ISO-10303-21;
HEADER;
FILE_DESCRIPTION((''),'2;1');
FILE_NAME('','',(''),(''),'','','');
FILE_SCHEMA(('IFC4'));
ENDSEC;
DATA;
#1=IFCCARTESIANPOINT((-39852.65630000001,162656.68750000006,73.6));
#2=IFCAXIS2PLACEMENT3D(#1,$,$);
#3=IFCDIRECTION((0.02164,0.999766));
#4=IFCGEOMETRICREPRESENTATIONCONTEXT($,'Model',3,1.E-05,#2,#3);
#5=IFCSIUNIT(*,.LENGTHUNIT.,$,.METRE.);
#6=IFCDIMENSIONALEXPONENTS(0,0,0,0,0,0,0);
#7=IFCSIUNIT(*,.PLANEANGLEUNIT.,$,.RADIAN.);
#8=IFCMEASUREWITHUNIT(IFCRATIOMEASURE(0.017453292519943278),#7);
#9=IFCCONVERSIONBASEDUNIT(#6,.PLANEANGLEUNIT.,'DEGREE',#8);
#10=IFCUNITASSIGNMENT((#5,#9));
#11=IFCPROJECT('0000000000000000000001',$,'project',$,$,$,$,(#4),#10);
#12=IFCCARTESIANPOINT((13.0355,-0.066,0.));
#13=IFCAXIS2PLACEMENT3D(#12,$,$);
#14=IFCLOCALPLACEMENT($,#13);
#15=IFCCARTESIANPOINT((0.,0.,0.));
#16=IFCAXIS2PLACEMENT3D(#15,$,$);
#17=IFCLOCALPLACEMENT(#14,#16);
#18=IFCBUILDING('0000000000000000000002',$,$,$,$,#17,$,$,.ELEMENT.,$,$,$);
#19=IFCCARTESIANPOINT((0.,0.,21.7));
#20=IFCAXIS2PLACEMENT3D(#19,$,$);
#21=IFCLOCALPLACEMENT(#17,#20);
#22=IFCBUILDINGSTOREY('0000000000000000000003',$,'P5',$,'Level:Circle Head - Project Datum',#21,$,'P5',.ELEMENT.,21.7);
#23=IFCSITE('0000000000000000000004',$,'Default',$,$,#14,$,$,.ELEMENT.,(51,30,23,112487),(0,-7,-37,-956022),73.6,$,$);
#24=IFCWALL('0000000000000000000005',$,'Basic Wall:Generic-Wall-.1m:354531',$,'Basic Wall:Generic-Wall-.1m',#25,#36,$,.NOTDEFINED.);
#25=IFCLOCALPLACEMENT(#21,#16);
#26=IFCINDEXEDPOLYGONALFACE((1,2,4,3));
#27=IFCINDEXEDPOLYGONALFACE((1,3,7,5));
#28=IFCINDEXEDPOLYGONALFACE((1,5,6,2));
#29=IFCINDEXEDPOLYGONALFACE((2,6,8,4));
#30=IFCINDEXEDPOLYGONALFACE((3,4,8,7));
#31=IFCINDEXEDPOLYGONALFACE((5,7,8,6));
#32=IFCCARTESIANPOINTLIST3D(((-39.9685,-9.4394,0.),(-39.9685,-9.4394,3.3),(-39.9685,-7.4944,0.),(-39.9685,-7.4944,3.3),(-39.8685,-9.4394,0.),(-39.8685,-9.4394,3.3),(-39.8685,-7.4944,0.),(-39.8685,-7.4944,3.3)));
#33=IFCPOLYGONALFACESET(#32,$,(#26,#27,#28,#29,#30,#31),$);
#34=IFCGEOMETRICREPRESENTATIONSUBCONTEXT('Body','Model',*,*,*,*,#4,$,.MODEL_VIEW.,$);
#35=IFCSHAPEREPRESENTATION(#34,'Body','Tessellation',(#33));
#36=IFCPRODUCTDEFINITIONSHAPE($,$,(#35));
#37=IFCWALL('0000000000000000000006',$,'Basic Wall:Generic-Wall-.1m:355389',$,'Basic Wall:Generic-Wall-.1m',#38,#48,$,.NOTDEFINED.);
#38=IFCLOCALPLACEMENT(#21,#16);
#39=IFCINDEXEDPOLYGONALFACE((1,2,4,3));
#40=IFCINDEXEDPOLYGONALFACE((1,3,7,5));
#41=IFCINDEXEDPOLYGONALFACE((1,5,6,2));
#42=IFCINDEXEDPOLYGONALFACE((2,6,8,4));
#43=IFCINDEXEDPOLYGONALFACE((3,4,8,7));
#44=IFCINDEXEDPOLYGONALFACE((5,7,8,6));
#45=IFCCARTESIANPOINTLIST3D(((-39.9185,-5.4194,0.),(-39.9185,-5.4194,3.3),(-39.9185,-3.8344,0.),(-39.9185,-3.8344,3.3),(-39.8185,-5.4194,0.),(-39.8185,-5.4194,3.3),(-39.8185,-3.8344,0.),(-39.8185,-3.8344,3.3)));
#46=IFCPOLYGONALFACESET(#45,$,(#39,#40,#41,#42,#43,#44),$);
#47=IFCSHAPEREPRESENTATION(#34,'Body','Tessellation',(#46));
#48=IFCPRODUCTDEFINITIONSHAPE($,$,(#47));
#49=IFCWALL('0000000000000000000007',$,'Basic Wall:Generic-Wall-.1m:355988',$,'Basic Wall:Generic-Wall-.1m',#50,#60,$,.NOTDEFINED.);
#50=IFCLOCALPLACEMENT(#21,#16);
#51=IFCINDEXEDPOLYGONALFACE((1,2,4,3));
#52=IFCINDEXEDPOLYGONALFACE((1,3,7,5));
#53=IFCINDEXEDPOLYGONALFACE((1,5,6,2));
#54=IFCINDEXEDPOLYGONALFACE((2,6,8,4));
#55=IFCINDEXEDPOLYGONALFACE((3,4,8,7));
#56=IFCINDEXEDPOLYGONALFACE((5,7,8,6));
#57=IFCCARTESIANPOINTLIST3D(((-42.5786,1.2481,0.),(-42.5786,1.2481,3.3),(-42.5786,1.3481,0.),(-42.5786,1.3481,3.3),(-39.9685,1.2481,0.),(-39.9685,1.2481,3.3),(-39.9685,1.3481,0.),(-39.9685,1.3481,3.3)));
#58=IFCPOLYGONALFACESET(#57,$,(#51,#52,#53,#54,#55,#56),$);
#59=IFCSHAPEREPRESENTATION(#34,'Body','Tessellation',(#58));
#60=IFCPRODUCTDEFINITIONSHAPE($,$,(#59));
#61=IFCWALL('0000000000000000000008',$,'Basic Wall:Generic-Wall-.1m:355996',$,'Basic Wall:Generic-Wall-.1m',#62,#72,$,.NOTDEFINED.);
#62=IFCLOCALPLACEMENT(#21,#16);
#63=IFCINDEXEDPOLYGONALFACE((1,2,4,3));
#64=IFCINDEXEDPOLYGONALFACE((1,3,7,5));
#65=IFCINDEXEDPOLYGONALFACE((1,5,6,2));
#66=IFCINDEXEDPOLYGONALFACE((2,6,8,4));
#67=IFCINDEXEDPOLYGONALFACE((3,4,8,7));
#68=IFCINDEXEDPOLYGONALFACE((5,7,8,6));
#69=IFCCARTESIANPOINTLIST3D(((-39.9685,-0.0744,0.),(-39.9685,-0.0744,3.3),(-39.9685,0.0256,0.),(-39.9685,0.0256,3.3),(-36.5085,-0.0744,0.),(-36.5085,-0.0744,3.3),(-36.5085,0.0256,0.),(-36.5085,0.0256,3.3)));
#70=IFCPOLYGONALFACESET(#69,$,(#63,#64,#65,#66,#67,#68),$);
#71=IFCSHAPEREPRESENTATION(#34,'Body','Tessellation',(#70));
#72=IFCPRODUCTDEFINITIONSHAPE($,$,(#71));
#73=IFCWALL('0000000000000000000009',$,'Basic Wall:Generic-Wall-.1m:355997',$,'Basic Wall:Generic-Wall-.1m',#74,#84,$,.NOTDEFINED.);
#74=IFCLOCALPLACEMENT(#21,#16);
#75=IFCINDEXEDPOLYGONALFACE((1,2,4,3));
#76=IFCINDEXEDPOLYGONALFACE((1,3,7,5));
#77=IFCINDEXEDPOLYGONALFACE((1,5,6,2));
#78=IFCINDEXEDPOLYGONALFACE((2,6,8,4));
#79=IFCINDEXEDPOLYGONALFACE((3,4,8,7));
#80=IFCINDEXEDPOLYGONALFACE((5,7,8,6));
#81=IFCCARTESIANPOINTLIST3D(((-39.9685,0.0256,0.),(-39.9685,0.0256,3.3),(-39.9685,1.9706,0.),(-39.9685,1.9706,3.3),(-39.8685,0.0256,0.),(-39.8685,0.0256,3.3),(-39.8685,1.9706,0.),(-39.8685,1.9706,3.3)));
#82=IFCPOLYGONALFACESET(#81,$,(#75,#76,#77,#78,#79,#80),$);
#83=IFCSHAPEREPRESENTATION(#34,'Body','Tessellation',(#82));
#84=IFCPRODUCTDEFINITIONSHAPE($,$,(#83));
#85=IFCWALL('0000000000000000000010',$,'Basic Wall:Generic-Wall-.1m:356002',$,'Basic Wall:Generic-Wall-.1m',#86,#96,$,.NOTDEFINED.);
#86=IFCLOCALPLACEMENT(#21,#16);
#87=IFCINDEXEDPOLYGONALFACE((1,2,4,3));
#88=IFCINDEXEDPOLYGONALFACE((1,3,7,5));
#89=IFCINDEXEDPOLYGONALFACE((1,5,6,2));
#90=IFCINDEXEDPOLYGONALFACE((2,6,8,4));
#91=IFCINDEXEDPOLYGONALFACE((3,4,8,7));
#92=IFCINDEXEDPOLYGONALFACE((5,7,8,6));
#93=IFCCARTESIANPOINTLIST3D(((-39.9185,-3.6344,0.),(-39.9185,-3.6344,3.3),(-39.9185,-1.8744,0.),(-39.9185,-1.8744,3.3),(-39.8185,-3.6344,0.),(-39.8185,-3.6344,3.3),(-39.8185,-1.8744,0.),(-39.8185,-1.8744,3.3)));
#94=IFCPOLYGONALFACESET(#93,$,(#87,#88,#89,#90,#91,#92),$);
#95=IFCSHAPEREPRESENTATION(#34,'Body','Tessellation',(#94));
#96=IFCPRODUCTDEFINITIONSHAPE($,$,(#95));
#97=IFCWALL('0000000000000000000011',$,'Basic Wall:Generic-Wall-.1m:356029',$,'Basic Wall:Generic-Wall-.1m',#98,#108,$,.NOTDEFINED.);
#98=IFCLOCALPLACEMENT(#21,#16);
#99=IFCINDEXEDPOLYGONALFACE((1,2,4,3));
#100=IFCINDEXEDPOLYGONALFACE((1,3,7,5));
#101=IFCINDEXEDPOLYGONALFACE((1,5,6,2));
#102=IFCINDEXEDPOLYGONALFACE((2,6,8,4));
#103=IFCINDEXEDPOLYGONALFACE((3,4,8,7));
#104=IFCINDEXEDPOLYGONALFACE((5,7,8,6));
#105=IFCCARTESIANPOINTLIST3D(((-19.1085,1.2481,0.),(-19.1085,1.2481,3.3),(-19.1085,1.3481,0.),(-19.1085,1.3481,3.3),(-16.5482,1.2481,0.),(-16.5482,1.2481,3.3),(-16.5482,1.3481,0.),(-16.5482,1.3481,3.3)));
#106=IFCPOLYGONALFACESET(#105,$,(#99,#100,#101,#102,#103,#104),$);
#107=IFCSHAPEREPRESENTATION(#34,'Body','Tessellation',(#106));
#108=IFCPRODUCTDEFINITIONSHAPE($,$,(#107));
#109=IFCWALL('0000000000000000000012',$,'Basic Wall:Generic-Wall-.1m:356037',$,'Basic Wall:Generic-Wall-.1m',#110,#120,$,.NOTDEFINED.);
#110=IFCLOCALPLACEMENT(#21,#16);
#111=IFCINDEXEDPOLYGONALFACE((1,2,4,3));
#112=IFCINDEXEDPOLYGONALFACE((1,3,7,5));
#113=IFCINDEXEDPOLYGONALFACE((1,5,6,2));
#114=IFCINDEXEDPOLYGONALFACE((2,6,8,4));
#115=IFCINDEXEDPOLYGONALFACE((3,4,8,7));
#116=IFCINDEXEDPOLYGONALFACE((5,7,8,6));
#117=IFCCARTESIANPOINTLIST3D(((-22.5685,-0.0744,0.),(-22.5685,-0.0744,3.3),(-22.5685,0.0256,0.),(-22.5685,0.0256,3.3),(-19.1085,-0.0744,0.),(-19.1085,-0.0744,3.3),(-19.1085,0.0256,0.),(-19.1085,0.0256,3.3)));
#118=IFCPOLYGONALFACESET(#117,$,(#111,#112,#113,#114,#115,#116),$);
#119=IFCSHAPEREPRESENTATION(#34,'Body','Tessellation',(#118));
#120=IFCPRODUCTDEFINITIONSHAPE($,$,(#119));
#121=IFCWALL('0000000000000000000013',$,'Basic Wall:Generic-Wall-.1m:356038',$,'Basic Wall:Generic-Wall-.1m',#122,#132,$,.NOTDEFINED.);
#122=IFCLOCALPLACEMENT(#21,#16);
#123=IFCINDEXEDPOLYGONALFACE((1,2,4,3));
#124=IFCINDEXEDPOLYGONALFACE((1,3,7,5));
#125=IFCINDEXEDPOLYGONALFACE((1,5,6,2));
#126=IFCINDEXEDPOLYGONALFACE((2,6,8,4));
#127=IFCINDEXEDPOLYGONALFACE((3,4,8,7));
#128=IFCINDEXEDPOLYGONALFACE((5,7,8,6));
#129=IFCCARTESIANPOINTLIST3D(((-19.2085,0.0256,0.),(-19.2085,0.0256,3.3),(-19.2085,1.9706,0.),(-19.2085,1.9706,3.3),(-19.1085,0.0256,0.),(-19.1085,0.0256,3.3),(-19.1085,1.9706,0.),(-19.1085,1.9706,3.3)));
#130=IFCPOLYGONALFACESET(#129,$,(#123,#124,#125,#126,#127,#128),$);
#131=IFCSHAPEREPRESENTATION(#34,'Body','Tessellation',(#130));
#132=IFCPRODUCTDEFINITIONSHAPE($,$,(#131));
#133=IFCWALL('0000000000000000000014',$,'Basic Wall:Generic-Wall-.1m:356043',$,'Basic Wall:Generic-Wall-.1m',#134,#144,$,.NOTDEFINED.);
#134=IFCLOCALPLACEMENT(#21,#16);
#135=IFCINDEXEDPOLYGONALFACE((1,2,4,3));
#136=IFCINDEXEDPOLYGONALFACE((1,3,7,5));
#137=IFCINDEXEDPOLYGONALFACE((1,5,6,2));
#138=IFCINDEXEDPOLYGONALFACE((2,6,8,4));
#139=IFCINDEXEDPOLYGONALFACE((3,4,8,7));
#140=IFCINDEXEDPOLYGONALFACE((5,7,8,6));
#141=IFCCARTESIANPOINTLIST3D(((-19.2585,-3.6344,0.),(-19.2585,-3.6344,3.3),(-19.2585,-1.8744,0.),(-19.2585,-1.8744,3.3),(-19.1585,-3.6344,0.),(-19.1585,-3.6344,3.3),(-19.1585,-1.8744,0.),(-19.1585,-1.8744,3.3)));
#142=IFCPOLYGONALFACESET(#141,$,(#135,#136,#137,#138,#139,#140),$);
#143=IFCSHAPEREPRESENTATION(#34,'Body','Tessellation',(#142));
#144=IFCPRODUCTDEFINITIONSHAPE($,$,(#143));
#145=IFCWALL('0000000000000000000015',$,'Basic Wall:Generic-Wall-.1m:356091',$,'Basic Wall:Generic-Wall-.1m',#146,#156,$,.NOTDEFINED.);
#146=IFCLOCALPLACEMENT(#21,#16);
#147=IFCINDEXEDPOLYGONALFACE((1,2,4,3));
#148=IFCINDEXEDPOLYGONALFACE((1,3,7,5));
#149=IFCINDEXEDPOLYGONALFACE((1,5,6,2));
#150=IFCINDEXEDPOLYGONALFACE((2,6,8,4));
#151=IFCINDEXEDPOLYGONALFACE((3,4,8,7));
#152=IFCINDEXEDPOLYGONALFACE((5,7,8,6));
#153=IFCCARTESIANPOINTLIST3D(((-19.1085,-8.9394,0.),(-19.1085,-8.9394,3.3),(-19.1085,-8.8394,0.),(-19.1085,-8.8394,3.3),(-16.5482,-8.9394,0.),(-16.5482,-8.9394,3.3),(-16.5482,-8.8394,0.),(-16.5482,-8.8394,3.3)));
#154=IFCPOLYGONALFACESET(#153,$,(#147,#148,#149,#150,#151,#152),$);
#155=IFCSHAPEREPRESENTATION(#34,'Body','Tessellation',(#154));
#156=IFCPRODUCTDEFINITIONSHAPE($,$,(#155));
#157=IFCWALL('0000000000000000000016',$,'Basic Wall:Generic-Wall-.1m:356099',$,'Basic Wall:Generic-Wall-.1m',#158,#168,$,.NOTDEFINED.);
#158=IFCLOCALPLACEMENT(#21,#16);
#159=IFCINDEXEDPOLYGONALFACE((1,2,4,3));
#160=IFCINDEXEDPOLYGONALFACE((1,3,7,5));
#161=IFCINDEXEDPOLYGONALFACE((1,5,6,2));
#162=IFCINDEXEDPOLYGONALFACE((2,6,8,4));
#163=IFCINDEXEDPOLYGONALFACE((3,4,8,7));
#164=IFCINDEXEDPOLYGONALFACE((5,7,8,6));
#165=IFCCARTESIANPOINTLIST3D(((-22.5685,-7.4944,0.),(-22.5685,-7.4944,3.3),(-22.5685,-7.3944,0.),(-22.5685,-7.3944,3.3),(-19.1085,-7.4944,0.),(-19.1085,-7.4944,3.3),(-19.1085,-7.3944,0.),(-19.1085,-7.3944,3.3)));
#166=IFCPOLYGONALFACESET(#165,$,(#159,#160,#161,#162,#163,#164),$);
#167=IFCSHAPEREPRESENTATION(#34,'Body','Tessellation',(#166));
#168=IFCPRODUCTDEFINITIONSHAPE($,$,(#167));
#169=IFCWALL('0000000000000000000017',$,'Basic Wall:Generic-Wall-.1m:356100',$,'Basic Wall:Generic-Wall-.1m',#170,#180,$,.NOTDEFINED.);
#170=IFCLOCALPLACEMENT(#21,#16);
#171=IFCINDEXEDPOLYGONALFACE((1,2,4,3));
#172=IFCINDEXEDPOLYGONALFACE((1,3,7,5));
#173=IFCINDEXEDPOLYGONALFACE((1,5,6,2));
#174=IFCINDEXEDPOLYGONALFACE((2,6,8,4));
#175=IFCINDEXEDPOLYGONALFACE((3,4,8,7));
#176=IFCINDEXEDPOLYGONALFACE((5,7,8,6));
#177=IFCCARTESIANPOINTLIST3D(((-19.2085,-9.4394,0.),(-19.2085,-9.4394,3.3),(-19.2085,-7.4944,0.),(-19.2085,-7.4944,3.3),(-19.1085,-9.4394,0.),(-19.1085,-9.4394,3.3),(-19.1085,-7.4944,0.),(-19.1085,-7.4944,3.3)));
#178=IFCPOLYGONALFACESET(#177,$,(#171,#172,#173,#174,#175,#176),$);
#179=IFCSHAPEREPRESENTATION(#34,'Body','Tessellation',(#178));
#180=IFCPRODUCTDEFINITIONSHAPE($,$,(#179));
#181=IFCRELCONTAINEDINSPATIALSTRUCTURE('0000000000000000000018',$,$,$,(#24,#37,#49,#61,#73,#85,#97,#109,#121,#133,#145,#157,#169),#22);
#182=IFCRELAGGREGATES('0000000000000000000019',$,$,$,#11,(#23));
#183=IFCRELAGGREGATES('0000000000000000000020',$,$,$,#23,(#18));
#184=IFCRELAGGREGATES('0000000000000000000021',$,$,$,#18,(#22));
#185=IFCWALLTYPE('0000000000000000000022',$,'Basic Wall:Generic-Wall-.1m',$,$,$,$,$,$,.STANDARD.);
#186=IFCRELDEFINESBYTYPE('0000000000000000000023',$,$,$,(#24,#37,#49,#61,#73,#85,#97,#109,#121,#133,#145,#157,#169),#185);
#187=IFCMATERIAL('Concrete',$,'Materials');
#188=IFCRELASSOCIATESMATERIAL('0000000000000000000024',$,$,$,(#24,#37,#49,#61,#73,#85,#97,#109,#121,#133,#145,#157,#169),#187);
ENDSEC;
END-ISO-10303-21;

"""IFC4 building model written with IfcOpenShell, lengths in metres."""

from ifc_helpers import new_model, entity, si_unit, converted_unit, direction, frame, origin, place, context, subcontext, project, spatial, indexed_curve, outline, extrude, material, type_object, element, save


model = new_model("IFC4")

# Units and contexts
model_context = context("Model", 3, precision=1e-05, world=frame((-39852.65630000001, 162656.68750000006, 73.6)), true_north=direction((0.02164, 0.999766)))
body_context = subcontext(model_context, "Body", "Model", "MODEL_VIEW")
ifc_project = project(units=[si_unit("LENGTHUNIT", "METRE"), converted_unit("PLANEANGLEUNIT", "DEGREE", entity("IfcRatioMeasure", 0.017453292519943278), si_unit("PLANEANGLEUNIT", "RADIAN"), dimensions=[0, 0, 0, 0, 0, 0, 0])], contexts=[model_context])

# Site, building, storey
site_placement = place(None, frame((13.0355, -0.066, 0.0)))
site = spatial("IfcSite", under=ifc_project, at=site_placement, Name="Default", CompositionType="ELEMENT", RefLatitude=(51, 30, 23, 112487), RefLongitude=(0, -7, -37, -956022), RefElevation=73.6)
building_placement = place(site_placement, origin())
building = spatial("IfcBuilding", under=site, at=building_placement, CompositionType="ELEMENT")
storey_placement = place(building_placement, frame((0.0, 0.0, 21.7)))
storey = spatial("IfcBuildingStorey", under=building, at=storey_placement, Name="P5", ObjectType="Level:Circle Head - Project Datum", LongName="P5", CompositionType="ELEMENT", Elevation=21.7)

# Shared definitions
ifc_material = material(Name="Concrete", Category="Materials")

# Walls
wall_type = type_object("IfcWallType", Name="Basic Wall:Generic-Wall-.1m", PredefinedType="STANDARD")
wall_1_placement = place(storey_placement, frame((-39.9185, -7.4944, 0.0), z_axis=(0.0, 0.0, 1.0), x_axis=(0.0, -1.0, 0.0)))
element("IfcWall", 1, at=wall_1_placement, inside=storey, type_object=wall_type, material=ifc_material, Name="Basic Wall:Generic-Wall-.1m:354531", ObjectType="Basic Wall:Generic-Wall-.1m", PredefinedType="NOTDEFINED", context=body_context, shape_type="SweptSolid", body=[
    extrude(outline(indexed_curve([(1.945, 0.05), (0.0, 0.05), (0.0, -0.05), (1.945, -0.05), (1.945, 0.05)], self_intersect=False)), origin(), (0.0, 0.0, 1.0), 3.3),
])
wall_2_placement = place(storey_placement, frame((-39.8685, -5.4194, 0.0), z_axis=(0.0, 0.0, 1.0), x_axis=(0.0, 1.0, 0.0)))
element("IfcWall", 2, at=wall_2_placement, inside=storey, type_object=wall_type, material=ifc_material, Name="Basic Wall:Generic-Wall-.1m:355389", ObjectType="Basic Wall:Generic-Wall-.1m", PredefinedType="NOTDEFINED", context=body_context, shape_type="SweptSolid", body=[
    extrude(outline(indexed_curve([(1.585, 0.05), (0.0, 0.05), (0.0, -0.05), (1.585, -0.05), (1.585, 0.05)], self_intersect=False)), origin(), (0.0, 0.0, 1.0), 3.3),
])
wall_3_placement = place(storey_placement, frame((-39.9685, 1.2981, 0.0), z_axis=(0.0, 0.0, 1.0), x_axis=(-1.0, 0.0, 0.0)))
element("IfcWall", 3, at=wall_3_placement, inside=storey, type_object=wall_type, material=ifc_material, Name="Basic Wall:Generic-Wall-.1m:355988", ObjectType="Basic Wall:Generic-Wall-.1m", PredefinedType="NOTDEFINED", context=body_context, shape_type="SweptSolid", body=[
    extrude(outline(indexed_curve([(2.6101, 0.05), (0.0, 0.05), (0.0, -0.05), (2.6101, -0.05), (2.6101, 0.05)], self_intersect=False)), origin(), (0.0, 0.0, 1.0), 3.3),
])
wall_4_placement = place(storey_placement, frame((-36.5085, -0.0244, 0.0), z_axis=(0.0, 0.0, 1.0), x_axis=(-1.0, 0.0, 0.0)))
element("IfcWall", 4, at=wall_4_placement, inside=storey, type_object=wall_type, material=ifc_material, Name="Basic Wall:Generic-Wall-.1m:355996", ObjectType="Basic Wall:Generic-Wall-.1m", PredefinedType="NOTDEFINED", context=body_context, shape_type="SweptSolid", body=[
    extrude(outline(indexed_curve([(3.46, 0.05), (0.0, 0.05), (0.0, -0.05), (3.46, -0.05), (3.46, 0.05)], self_intersect=False)), origin(), (0.0, 0.0, 1.0), 3.3),
])
wall_5_placement = place(storey_placement, frame((-39.9185, 0.0256, 0.0), z_axis=(0.0, 0.0, 1.0), x_axis=(0.0, 1.0, 0.0)))
element("IfcWall", 5, at=wall_5_placement, inside=storey, type_object=wall_type, material=ifc_material, Name="Basic Wall:Generic-Wall-.1m:355997", ObjectType="Basic Wall:Generic-Wall-.1m", PredefinedType="NOTDEFINED", context=body_context, shape_type="SweptSolid", body=[
    extrude(outline(indexed_curve([(1.945, 0.05), (0.0, 0.05), (0.0, -0.05), (1.945, -0.05), (1.945, 0.05)], self_intersect=False)), origin(), (0.0, 0.0, 1.0), 3.3),
])
wall_6_placement = place(storey_placement, frame((-39.8685, -1.8744, 0.0), z_axis=(0.0, 0.0, 1.0), x_axis=(0.0, -1.0, 0.0)))
element("IfcWall", 6, at=wall_6_placement, inside=storey, type_object=wall_type, material=ifc_material, Name="Basic Wall:Generic-Wall-.1m:356002", ObjectType="Basic Wall:Generic-Wall-.1m", PredefinedType="NOTDEFINED", context=body_context, shape_type="SweptSolid", body=[
    extrude(outline(indexed_curve([(1.76, 0.05), (0.0, 0.05), (0.0, -0.05), (1.76, -0.05), (1.76, 0.05)], self_intersect=False)), origin(), (0.0, 0.0, 1.0), 3.3),
])
wall_7_placement = place(storey_placement, frame((-19.1085, 1.2981, 0.0)))
element("IfcWall", 7, at=wall_7_placement, inside=storey, type_object=wall_type, material=ifc_material, Name="Basic Wall:Generic-Wall-.1m:356029", ObjectType="Basic Wall:Generic-Wall-.1m", PredefinedType="NOTDEFINED", context=body_context, shape_type="SweptSolid", body=[
    extrude(outline(indexed_curve([(2.5602, 0.05), (0.0, 0.05), (0.0, -0.05), (2.5602, -0.05), (2.5602, 0.05)], self_intersect=False)), origin(), (0.0, 0.0, 1.0), 3.3),
])
wall_8_placement = place(storey_placement, frame((-22.5685, -0.0244, 0.0)))
element("IfcWall", 8, at=wall_8_placement, inside=storey, type_object=wall_type, material=ifc_material, Name="Basic Wall:Generic-Wall-.1m:356037", ObjectType="Basic Wall:Generic-Wall-.1m", PredefinedType="NOTDEFINED", context=body_context, shape_type="SweptSolid", body=[
    extrude(outline(indexed_curve([(3.46, 0.05), (0.0, 0.05), (0.0, -0.05), (3.46, -0.05), (3.46, 0.05)], self_intersect=False)), origin(), (0.0, 0.0, 1.0), 3.3),
])
wall_9_placement = place(storey_placement, frame((-19.1585, 0.0256, 0.0), z_axis=(0.0, 0.0, 1.0), x_axis=(0.0, 1.0, 0.0)))
element("IfcWall", 9, at=wall_9_placement, inside=storey, type_object=wall_type, material=ifc_material, Name="Basic Wall:Generic-Wall-.1m:356038", ObjectType="Basic Wall:Generic-Wall-.1m", PredefinedType="NOTDEFINED", context=body_context, shape_type="SweptSolid", body=[
    extrude(outline(indexed_curve([(1.945, 0.05), (0.0, 0.05), (0.0, -0.05), (1.945, -0.05), (1.945, 0.05)], self_intersect=False)), origin(), (0.0, 0.0, 1.0), 3.3),
])
wall_10_placement = place(storey_placement, frame((-19.2085, -1.8744, 0.0), z_axis=(0.0, 0.0, 1.0), x_axis=(0.0, -1.0, 0.0)))
element("IfcWall", 10, at=wall_10_placement, inside=storey, type_object=wall_type, material=ifc_material, Name="Basic Wall:Generic-Wall-.1m:356043", ObjectType="Basic Wall:Generic-Wall-.1m", PredefinedType="NOTDEFINED", context=body_context, shape_type="SweptSolid", body=[
    extrude(outline(indexed_curve([(1.76, 0.05), (0.0, 0.05), (0.0, -0.05), (1.76, -0.05), (1.76, 0.05)], self_intersect=False)), origin(), (0.0, 0.0, 1.0), 3.3),
])
wall_11_placement = place(storey_placement, frame((-19.1085, -8.8894, 0.0)))
element("IfcWall", 11, at=wall_11_placement, inside=storey, type_object=wall_type, material=ifc_material, Name="Basic Wall:Generic-Wall-.1m:356091", ObjectType="Basic Wall:Generic-Wall-.1m", PredefinedType="NOTDEFINED", context=body_context, shape_type="SweptSolid", body=[
    extrude(outline(indexed_curve([(2.5602, 0.05), (0.0, 0.05), (0.0, -0.05), (2.5602, -0.05), (2.5602, 0.05)], self_intersect=False)), origin(), (0.0, 0.0, 1.0), 3.3),
])
wall_12_placement = place(storey_placement, frame((-22.5685, -7.4444, 0.0)))
element("IfcWall", 12, at=wall_12_placement, inside=storey, type_object=wall_type, material=ifc_material, Name="Basic Wall:Generic-Wall-.1m:356099", ObjectType="Basic Wall:Generic-Wall-.1m", PredefinedType="NOTDEFINED", context=body_context, shape_type="SweptSolid", body=[
    extrude(outline(indexed_curve([(3.46, 0.05), (0.0, 0.05), (0.0, -0.05), (3.46, -0.05), (3.46, 0.05)], self_intersect=False)), origin(), (0.0, 0.0, 1.0), 3.3),
])
wall_13_placement = place(storey_placement, frame((-19.1585, -7.4944, 0.0), z_axis=(0.0, 0.0, 1.0), x_axis=(0.0, -1.0, 0.0)))
element("IfcWall", 13, at=wall_13_placement, inside=storey, type_object=wall_type, material=ifc_material, Name="Basic Wall:Generic-Wall-.1m:356100", ObjectType="Basic Wall:Generic-Wall-.1m", PredefinedType="NOTDEFINED", context=body_context, shape_type="SweptSolid", body=[
    extrude(outline(indexed_curve([(1.945, 0.05), (0.0, 0.05), (0.0, -0.05), (1.945, -0.05), (1.945, 0.05)], self_intersect=False)), origin(), (0.0, 0.0, 1.0), 3.3),
])

save(model, "model.ifc")
